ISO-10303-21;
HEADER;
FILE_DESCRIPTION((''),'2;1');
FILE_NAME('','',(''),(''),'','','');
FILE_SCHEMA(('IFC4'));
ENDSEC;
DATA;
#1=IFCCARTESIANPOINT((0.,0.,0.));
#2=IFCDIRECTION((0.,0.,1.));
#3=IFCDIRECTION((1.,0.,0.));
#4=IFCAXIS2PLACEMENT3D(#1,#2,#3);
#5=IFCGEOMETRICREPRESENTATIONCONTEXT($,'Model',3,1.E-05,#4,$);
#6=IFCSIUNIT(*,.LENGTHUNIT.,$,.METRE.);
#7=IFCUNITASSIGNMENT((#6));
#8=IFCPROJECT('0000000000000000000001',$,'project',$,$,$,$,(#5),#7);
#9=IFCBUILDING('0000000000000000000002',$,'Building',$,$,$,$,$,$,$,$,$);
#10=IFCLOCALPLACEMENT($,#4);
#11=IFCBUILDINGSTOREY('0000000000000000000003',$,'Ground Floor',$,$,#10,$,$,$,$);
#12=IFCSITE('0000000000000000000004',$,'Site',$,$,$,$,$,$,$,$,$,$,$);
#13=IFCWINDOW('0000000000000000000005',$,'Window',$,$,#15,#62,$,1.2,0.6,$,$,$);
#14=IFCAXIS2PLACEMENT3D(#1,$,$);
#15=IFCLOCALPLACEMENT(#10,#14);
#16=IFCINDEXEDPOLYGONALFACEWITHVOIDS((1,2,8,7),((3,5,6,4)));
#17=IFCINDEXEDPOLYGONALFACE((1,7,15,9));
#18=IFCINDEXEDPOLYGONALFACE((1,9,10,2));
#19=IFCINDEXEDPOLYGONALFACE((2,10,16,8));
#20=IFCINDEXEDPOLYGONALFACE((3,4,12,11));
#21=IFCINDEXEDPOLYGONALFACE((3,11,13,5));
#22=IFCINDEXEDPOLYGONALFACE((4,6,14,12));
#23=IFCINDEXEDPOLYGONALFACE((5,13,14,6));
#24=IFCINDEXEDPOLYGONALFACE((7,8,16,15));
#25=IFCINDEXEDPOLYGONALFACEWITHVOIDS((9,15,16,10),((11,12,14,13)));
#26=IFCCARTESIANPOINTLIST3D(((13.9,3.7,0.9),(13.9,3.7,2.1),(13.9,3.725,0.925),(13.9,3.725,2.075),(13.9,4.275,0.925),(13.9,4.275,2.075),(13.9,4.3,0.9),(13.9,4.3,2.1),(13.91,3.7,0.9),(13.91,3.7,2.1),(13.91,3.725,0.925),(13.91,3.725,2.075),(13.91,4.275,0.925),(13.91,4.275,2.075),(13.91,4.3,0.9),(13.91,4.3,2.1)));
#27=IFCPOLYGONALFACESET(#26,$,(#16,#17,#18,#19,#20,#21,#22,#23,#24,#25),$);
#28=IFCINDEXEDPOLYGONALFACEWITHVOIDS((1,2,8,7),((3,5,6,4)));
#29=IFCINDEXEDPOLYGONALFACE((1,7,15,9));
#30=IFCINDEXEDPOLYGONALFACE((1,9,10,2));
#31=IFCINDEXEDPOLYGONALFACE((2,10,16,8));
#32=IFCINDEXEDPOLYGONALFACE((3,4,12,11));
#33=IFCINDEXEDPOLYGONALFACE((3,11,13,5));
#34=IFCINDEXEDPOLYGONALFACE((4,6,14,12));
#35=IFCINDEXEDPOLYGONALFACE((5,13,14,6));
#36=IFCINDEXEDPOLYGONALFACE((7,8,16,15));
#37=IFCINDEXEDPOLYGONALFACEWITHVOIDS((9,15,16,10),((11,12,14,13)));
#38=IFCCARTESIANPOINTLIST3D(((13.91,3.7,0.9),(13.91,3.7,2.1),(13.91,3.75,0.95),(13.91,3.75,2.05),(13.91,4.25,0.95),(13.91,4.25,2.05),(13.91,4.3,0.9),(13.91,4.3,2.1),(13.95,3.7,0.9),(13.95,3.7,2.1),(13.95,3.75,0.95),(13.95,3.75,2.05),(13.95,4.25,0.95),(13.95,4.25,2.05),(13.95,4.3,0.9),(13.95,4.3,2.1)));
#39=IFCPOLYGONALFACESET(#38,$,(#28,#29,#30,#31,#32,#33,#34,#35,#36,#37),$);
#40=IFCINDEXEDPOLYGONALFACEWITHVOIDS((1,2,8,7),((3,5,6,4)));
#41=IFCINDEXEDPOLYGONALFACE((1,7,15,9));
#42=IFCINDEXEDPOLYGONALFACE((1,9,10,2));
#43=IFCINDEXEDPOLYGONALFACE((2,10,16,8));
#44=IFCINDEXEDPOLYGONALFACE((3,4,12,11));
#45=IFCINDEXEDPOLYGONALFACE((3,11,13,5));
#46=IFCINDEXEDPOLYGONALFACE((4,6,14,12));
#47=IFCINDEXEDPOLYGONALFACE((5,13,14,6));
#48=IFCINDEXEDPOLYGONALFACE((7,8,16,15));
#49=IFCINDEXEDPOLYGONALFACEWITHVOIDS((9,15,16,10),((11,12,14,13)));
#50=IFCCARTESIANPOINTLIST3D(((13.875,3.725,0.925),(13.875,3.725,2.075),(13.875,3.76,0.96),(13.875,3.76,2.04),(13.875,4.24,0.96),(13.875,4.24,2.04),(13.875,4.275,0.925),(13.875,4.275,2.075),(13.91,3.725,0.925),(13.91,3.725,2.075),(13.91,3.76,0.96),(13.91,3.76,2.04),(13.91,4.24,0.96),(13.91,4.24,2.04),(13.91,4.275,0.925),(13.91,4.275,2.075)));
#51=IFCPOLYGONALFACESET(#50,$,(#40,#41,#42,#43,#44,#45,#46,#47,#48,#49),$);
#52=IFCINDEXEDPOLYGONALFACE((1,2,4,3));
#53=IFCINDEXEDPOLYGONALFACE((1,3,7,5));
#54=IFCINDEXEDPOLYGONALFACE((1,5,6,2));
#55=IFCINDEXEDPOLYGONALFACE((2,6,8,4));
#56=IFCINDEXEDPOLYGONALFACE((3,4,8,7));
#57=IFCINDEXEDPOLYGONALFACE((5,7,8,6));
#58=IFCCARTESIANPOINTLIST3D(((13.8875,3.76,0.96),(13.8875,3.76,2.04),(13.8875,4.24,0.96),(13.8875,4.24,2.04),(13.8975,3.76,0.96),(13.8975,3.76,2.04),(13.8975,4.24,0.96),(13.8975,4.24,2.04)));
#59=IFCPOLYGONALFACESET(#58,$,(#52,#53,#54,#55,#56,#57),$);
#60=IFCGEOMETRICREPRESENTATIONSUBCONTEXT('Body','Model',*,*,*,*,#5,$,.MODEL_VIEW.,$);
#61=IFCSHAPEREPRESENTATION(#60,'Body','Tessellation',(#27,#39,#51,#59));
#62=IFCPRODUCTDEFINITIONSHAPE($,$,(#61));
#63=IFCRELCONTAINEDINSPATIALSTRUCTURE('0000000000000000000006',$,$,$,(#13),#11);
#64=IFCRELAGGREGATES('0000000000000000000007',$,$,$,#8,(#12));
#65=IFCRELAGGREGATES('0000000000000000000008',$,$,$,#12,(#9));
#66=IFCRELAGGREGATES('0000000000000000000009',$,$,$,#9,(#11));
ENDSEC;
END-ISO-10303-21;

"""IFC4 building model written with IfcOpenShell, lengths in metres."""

from ifc_helpers import new_model, si_unit, frame, origin_with_axes, place, context, subcontext, project, spatial, line, indexed_curve, outline, extrude, element, save


model = new_model("IFC4")

# Units and contexts
model_context = context("Model", 3, precision=1e-05, world=origin_with_axes())
body_context = subcontext(model_context, "Body", "Model", "MODEL_VIEW")
ifc_project = project(units=[si_unit("LENGTHUNIT", "METRE")], contexts=[model_context])

# Site, building, storey
site = spatial("IfcSite", under=ifc_project, Name="Site")
building = spatial("IfcBuilding", under=site, Name="Building")
storey_placement = place(None, origin_with_axes())
storey = spatial("IfcBuildingStorey", under=building, at=storey_placement, Name="Ground Floor")

# Window
window_1_placement = place(storey_placement, frame((14.0, 3.7, 0.9), z_axis=(0.0, 0.0, 1.0), x_axis=(0.0, 1.0, 0.0)))
element("IfcWindow", 1, at=window_1_placement, inside=storey, Name="Window", OverallHeight=1.2, OverallWidth=0.6, context=body_context, shape_type="SweptSolid", body=[
    extrude(outline(indexed_curve([(0.0, 0.0), (0.6, 0.0), (0.6, 1.2), (0.0, 1.2)], segments=[line(1, 2, 3, 4, 1)]), holes=[indexed_curve([(0.025, 0.025), (0.575, 0.025), (0.575, 1.175), (0.025, 1.175)], segments=[line(1, 2, 3, 4, 1)])]), frame((0.0, 0.09, 0.0), z_axis=(0.0, -1.0, 0.0), x_axis=(1.0, 0.0, 0.0)), (0.0, 0.0, -1.0), 0.01),
    extrude(outline(indexed_curve([(0.0, 0.0), (0.6, 0.0), (0.6, 1.2), (0.0, 1.2)], segments=[line(1, 2, 3, 4, 1)]), holes=[indexed_curve([(0.05, 0.05), (0.55, 0.05), (0.55, 1.15), (0.05, 1.15)], segments=[line(1, 2, 3, 4, 1)])]), frame((0.0, 0.05, 0.0), z_axis=(0.0, -1.0, 0.0), x_axis=(1.0, 0.0, 0.0)), (0.0, 0.0, -1.0), 0.04),
    extrude(outline(indexed_curve([(0.0, 0.0), (0.55, 0.0), (0.55, 1.15), (0.0, 1.15)], segments=[line(1, 2, 3, 4, 1)]), holes=[indexed_curve([(0.035, 0.035), (0.515, 0.035), (0.515, 1.115), (0.035, 1.115)], segments=[line(1, 2, 3, 4, 1)])]), frame((0.025, 0.09, 0.025), z_axis=(0.0, -1.0, 0.0), x_axis=(1.0, 0.0, 0.0)), (0.0, 0.0, -1.0), 0.035),
    extrude(outline(indexed_curve([(0.035, 0.035), (0.515, 0.035), (0.515, 1.115), (0.035, 1.115)], segments=[line(1, 2, 3, 4, 1)])), frame((0.025, 0.1025, 0.025), z_axis=(0.0, -1.0, 0.0), x_axis=(1.0, 0.0, 0.0)), (0.0, 0.0, -1.0), 0.01),
])

save(model, "model.ifc")
